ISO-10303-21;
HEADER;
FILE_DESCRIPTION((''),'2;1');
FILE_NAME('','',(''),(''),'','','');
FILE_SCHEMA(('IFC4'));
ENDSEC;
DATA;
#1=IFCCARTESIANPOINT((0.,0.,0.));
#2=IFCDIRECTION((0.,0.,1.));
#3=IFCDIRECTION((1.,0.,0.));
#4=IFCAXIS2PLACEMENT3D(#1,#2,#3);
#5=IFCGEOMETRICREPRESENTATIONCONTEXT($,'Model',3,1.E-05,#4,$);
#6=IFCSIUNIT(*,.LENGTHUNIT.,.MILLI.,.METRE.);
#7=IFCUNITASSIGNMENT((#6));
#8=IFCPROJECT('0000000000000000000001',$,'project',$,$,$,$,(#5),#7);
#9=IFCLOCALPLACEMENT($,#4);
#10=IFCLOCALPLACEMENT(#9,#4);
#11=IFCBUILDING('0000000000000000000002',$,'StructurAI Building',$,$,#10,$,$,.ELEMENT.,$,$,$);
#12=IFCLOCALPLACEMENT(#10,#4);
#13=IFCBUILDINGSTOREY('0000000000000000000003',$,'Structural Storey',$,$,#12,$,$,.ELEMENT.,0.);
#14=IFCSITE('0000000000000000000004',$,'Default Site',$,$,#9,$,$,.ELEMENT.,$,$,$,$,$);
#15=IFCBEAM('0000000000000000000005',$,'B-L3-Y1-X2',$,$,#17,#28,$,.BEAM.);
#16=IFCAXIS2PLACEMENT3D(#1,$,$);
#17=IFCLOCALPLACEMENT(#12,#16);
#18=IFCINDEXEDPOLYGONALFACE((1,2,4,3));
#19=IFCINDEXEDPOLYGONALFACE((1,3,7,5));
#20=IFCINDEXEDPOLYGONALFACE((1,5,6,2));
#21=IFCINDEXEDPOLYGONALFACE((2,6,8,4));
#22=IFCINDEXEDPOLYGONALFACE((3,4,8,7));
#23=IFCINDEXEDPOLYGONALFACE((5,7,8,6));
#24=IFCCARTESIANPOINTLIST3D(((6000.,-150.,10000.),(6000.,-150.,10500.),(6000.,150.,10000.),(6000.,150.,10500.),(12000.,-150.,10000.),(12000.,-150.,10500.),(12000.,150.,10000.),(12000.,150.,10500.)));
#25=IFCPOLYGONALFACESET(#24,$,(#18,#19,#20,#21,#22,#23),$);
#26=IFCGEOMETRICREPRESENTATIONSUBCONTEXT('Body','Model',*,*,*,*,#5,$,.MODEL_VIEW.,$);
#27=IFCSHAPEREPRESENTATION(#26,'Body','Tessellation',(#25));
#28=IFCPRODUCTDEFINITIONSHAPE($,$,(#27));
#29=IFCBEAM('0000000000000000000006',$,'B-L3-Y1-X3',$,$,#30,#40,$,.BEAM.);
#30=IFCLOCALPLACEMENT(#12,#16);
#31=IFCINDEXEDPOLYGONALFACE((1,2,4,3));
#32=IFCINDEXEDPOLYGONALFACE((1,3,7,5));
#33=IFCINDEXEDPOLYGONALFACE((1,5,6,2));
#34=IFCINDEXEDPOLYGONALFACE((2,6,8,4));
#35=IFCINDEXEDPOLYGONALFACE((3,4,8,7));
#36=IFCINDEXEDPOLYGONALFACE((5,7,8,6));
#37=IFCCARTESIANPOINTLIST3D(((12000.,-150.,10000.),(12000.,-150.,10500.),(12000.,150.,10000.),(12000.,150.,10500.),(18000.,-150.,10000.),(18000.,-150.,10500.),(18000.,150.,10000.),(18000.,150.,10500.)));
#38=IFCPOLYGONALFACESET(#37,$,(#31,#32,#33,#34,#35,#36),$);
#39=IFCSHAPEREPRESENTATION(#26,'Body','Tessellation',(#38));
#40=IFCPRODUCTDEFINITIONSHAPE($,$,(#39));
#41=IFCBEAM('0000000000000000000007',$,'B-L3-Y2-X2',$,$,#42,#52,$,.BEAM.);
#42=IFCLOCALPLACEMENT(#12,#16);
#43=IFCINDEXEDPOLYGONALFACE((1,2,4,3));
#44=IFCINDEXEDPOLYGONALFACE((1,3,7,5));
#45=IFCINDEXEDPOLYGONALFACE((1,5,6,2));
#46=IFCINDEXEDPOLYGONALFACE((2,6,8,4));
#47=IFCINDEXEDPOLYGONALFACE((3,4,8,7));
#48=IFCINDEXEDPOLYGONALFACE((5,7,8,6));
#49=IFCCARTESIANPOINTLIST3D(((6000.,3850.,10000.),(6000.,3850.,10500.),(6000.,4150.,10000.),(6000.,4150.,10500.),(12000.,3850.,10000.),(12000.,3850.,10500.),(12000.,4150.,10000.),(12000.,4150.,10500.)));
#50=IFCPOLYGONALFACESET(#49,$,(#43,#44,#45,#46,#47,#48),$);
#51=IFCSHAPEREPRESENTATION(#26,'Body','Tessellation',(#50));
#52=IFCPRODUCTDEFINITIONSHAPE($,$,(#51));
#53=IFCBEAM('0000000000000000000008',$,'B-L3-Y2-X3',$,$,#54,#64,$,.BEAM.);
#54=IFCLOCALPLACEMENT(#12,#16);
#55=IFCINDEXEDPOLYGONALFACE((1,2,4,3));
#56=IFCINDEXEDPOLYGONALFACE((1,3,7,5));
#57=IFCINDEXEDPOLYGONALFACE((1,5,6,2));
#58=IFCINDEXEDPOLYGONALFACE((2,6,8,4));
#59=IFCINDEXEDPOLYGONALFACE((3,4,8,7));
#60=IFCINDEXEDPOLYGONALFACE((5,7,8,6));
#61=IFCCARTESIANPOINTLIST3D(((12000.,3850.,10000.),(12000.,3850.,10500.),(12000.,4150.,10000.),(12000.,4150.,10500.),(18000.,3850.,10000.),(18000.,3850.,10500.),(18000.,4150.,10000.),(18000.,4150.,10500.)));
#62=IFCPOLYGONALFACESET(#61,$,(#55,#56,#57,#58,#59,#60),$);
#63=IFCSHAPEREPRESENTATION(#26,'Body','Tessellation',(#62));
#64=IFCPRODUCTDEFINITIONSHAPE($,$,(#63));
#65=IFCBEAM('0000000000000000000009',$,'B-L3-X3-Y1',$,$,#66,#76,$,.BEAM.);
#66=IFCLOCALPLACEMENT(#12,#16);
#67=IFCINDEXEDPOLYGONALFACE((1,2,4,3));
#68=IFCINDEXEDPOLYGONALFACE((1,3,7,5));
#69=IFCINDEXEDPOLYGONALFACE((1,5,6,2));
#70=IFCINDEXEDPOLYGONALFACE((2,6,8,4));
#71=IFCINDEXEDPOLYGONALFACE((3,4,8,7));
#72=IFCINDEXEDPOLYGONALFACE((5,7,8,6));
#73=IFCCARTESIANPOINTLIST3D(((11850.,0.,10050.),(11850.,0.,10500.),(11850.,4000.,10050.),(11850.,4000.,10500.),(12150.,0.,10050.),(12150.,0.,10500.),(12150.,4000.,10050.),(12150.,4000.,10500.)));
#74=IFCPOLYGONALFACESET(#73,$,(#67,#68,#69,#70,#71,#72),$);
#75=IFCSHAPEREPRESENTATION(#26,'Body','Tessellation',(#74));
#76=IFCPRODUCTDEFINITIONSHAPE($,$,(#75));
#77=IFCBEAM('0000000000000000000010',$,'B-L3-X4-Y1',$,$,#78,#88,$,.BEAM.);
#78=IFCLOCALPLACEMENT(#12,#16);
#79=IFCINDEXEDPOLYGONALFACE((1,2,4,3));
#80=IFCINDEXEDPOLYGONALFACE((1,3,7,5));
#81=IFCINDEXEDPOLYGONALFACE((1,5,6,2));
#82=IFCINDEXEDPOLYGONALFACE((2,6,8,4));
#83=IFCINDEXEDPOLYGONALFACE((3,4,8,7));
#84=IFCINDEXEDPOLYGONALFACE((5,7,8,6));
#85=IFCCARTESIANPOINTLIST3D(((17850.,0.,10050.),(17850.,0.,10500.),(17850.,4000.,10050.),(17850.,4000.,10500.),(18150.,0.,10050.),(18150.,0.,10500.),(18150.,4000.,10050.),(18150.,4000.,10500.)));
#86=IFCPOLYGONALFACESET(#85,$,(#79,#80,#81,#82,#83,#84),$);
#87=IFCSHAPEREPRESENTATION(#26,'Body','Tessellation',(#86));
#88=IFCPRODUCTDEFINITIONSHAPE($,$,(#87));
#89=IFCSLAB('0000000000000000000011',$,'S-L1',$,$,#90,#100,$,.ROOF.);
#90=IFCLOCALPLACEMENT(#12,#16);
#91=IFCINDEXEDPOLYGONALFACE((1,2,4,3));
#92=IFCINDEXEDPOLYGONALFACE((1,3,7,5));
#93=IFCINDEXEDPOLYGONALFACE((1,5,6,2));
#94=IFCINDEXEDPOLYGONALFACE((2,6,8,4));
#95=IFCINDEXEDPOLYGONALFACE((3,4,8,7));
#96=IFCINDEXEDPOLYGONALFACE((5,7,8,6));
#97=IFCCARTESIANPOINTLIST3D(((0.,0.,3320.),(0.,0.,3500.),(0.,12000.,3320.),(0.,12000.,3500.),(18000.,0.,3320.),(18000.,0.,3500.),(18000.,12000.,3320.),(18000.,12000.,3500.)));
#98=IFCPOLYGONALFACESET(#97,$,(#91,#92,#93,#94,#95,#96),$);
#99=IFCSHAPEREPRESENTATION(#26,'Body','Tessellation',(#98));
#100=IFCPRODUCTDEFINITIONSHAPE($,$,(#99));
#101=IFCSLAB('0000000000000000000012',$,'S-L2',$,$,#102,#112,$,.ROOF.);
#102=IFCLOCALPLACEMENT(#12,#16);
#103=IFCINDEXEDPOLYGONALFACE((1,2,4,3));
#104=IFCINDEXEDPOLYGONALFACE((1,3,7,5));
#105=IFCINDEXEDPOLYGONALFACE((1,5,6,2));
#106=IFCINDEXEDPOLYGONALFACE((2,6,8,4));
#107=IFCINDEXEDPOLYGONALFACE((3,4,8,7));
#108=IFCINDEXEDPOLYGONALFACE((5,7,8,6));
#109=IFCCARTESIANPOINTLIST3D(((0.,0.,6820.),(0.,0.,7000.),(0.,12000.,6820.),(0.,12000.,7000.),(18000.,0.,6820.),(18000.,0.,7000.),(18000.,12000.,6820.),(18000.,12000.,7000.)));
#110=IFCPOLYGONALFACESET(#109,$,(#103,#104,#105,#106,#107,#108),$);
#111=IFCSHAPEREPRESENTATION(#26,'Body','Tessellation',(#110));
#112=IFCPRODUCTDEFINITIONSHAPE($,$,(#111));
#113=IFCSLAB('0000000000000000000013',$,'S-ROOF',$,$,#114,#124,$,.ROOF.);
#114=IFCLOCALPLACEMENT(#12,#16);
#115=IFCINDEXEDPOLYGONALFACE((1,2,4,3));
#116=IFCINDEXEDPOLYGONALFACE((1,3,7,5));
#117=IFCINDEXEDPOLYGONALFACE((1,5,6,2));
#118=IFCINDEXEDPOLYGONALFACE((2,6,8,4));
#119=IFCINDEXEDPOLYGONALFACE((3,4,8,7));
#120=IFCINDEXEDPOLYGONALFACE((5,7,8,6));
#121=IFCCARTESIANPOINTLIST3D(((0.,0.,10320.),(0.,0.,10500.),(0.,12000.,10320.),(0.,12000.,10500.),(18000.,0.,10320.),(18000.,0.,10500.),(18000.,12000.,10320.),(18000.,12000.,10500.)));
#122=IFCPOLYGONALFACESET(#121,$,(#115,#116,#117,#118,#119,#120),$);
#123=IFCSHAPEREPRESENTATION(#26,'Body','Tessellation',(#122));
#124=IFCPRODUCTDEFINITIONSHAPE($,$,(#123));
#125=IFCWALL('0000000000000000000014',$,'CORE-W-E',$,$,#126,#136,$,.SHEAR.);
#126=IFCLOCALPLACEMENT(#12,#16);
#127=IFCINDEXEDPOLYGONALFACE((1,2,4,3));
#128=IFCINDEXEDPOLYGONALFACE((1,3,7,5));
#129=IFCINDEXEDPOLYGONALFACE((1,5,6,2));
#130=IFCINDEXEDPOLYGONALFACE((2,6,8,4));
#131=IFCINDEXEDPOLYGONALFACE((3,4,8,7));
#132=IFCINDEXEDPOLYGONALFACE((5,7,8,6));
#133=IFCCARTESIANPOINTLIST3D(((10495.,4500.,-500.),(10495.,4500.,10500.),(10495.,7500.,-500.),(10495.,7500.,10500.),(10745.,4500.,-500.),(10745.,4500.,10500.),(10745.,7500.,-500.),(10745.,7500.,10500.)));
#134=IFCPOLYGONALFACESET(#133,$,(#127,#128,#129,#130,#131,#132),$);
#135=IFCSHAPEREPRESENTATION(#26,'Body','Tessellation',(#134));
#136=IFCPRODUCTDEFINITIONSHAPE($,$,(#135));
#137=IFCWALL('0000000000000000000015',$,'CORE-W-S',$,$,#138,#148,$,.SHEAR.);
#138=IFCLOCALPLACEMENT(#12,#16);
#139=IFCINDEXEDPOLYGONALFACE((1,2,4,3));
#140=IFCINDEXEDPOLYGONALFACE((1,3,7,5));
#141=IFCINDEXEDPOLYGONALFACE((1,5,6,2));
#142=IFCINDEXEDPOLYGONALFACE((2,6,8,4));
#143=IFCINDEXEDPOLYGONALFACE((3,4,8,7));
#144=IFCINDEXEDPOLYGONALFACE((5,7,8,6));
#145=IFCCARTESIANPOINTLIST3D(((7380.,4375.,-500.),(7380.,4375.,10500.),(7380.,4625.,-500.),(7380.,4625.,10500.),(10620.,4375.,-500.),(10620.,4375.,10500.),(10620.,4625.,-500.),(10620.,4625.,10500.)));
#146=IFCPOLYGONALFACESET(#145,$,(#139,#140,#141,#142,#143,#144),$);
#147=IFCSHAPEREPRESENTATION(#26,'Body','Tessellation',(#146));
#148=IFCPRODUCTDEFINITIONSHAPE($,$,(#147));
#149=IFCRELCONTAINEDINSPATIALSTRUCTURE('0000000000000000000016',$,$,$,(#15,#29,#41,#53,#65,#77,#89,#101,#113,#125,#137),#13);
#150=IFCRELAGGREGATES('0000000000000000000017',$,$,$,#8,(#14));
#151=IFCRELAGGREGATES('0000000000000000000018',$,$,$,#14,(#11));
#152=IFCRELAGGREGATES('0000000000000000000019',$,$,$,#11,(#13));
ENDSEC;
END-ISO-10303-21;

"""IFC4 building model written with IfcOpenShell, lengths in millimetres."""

from ifc_helpers import new_model, si_unit, frame, origin_with_axes, place, context, subcontext, project, spatial, rectangle, extrude, element, save


model = new_model("IFC4")

# Units and contexts
model_context = context("Model", 3, precision=1e-05, world=origin_with_axes())
body_context = subcontext(model_context, "Body", "Model", "MODEL_VIEW")
ifc_project = project(units=[si_unit("LENGTHUNIT", "METRE", prefix="MILLI")], contexts=[model_context])

# Site, building, storey
site_placement = place(None, origin_with_axes())
site = spatial("IfcSite", under=ifc_project, at=site_placement, Name="Default Site", CompositionType="ELEMENT")
building_placement = place(site_placement, origin_with_axes())
building = spatial("IfcBuilding", under=site, at=building_placement, Name="StructurAI Building", CompositionType="ELEMENT")
storey_placement = place(building_placement, origin_with_axes())
storey = spatial("IfcBuildingStorey", under=building, at=storey_placement, Name="Structural Storey", CompositionType="ELEMENT", Elevation=0.0)

# Beams
for number, where, z_axis, x_axis, name in (
    (1, (9000.0, 0.0, 10000.0), (0.0, 0.0, 1.0), (1.0, 0.0, 0.0), "B-L3-Y1-X2"),
    (2, (15000.0, 0.0, 10000.0), (0.0, 0.0, 1.0), (1.0, 0.0, 0.0), "B-L3-Y1-X3"),
    (3, (9000.0, 4000.0, 10000.0), (0.0, 0.0, 1.0), (1.0, 0.0, 0.0), "B-L3-Y2-X2"),
    (4, (15000.0, 4000.0, 10000.0), (0.0, 0.0, 1.0), (1.0, 0.0, 0.0), "B-L3-Y2-X3"),
):
    element("IfcBeam", number, at=place(storey_placement, frame(where, z_axis=z_axis, x_axis=x_axis)), inside=storey, Name=name, PredefinedType="BEAM", context=body_context, shape_type="SweptSolid", body=[
        extrude(rectangle(XDim=6000.0, YDim=300.0), origin_with_axes(), (0.0, 0.0, 1.0), 500.0),
    ])
for number, where, z_axis, x_axis, name in (
    (5, (12000.0, 2000.0, 10050.0), (0.0, 0.0, 1.0), (0.0, 1.0, 0.0), "B-L3-X3-Y1"),
    (6, (18000.0, 2000.0, 10050.0), (0.0, 0.0, 1.0), (0.0, 1.0, 0.0), "B-L3-X4-Y1"),
):
    element("IfcBeam", number, at=place(storey_placement, frame(where, z_axis=z_axis, x_axis=x_axis)), inside=storey, Name=name, PredefinedType="BEAM", context=body_context, shape_type="SweptSolid", body=[
        extrude(rectangle(XDim=4000.0, YDim=300.0), origin_with_axes(), (0.0, 0.0, 1.0), 450.0),
    ])

# Slabs
for number, where, z_axis, x_axis, name in (
    (7, (9000.0, 6000.0, 3320.0), (0.0, 0.0, 1.0), (1.0, 0.0, 0.0), "S-L1"),
    (8, (9000.0, 6000.0, 6820.0), (0.0, 0.0, 1.0), (1.0, 0.0, 0.0), "S-L2"),
    (9, (9000.0, 6000.0, 10320.0), (0.0, 0.0, 1.0), (1.0, 0.0, 0.0), "S-ROOF"),
):
    element("IfcSlab", number, at=place(storey_placement, frame(where, z_axis=z_axis, x_axis=x_axis)), inside=storey, Name=name, PredefinedType="ROOF", context=body_context, shape_type="SweptSolid", body=[
        extrude(rectangle(XDim=18000.0, YDim=12000.0), origin_with_axes(), (0.0, 0.0, 1.0), 180.0),
    ])

# Walls
wall_1_placement = place(storey_placement, frame((10620.0, 6000.0, -500.0), z_axis=(0.0, 0.0, 1.0), x_axis=(0.0, 1.0, 0.0)))
element("IfcWall", 10, at=wall_1_placement, inside=storey, Name="CORE-W-E", PredefinedType="SHEAR", context=body_context, shape_type="SweptSolid", body=[
    extrude(rectangle(XDim=3000.0, YDim=250.0), origin_with_axes(), (0.0, 0.0, 1.0), 11000.0),
])
wall_2_placement = place(storey_placement, frame((9000.0, 4500.0, -500.0), z_axis=(0.0, 0.0, 1.0), x_axis=(1.0, 0.0, 0.0)))
element("IfcWall", 11, at=wall_2_placement, inside=storey, Name="CORE-W-S", PredefinedType="SHEAR", context=body_context, shape_type="SweptSolid", body=[
    extrude(rectangle(XDim=3240.0, YDim=250.0), origin_with_axes(), (0.0, 0.0, 1.0), 11000.0),
])

save(model, "model.ifc")
